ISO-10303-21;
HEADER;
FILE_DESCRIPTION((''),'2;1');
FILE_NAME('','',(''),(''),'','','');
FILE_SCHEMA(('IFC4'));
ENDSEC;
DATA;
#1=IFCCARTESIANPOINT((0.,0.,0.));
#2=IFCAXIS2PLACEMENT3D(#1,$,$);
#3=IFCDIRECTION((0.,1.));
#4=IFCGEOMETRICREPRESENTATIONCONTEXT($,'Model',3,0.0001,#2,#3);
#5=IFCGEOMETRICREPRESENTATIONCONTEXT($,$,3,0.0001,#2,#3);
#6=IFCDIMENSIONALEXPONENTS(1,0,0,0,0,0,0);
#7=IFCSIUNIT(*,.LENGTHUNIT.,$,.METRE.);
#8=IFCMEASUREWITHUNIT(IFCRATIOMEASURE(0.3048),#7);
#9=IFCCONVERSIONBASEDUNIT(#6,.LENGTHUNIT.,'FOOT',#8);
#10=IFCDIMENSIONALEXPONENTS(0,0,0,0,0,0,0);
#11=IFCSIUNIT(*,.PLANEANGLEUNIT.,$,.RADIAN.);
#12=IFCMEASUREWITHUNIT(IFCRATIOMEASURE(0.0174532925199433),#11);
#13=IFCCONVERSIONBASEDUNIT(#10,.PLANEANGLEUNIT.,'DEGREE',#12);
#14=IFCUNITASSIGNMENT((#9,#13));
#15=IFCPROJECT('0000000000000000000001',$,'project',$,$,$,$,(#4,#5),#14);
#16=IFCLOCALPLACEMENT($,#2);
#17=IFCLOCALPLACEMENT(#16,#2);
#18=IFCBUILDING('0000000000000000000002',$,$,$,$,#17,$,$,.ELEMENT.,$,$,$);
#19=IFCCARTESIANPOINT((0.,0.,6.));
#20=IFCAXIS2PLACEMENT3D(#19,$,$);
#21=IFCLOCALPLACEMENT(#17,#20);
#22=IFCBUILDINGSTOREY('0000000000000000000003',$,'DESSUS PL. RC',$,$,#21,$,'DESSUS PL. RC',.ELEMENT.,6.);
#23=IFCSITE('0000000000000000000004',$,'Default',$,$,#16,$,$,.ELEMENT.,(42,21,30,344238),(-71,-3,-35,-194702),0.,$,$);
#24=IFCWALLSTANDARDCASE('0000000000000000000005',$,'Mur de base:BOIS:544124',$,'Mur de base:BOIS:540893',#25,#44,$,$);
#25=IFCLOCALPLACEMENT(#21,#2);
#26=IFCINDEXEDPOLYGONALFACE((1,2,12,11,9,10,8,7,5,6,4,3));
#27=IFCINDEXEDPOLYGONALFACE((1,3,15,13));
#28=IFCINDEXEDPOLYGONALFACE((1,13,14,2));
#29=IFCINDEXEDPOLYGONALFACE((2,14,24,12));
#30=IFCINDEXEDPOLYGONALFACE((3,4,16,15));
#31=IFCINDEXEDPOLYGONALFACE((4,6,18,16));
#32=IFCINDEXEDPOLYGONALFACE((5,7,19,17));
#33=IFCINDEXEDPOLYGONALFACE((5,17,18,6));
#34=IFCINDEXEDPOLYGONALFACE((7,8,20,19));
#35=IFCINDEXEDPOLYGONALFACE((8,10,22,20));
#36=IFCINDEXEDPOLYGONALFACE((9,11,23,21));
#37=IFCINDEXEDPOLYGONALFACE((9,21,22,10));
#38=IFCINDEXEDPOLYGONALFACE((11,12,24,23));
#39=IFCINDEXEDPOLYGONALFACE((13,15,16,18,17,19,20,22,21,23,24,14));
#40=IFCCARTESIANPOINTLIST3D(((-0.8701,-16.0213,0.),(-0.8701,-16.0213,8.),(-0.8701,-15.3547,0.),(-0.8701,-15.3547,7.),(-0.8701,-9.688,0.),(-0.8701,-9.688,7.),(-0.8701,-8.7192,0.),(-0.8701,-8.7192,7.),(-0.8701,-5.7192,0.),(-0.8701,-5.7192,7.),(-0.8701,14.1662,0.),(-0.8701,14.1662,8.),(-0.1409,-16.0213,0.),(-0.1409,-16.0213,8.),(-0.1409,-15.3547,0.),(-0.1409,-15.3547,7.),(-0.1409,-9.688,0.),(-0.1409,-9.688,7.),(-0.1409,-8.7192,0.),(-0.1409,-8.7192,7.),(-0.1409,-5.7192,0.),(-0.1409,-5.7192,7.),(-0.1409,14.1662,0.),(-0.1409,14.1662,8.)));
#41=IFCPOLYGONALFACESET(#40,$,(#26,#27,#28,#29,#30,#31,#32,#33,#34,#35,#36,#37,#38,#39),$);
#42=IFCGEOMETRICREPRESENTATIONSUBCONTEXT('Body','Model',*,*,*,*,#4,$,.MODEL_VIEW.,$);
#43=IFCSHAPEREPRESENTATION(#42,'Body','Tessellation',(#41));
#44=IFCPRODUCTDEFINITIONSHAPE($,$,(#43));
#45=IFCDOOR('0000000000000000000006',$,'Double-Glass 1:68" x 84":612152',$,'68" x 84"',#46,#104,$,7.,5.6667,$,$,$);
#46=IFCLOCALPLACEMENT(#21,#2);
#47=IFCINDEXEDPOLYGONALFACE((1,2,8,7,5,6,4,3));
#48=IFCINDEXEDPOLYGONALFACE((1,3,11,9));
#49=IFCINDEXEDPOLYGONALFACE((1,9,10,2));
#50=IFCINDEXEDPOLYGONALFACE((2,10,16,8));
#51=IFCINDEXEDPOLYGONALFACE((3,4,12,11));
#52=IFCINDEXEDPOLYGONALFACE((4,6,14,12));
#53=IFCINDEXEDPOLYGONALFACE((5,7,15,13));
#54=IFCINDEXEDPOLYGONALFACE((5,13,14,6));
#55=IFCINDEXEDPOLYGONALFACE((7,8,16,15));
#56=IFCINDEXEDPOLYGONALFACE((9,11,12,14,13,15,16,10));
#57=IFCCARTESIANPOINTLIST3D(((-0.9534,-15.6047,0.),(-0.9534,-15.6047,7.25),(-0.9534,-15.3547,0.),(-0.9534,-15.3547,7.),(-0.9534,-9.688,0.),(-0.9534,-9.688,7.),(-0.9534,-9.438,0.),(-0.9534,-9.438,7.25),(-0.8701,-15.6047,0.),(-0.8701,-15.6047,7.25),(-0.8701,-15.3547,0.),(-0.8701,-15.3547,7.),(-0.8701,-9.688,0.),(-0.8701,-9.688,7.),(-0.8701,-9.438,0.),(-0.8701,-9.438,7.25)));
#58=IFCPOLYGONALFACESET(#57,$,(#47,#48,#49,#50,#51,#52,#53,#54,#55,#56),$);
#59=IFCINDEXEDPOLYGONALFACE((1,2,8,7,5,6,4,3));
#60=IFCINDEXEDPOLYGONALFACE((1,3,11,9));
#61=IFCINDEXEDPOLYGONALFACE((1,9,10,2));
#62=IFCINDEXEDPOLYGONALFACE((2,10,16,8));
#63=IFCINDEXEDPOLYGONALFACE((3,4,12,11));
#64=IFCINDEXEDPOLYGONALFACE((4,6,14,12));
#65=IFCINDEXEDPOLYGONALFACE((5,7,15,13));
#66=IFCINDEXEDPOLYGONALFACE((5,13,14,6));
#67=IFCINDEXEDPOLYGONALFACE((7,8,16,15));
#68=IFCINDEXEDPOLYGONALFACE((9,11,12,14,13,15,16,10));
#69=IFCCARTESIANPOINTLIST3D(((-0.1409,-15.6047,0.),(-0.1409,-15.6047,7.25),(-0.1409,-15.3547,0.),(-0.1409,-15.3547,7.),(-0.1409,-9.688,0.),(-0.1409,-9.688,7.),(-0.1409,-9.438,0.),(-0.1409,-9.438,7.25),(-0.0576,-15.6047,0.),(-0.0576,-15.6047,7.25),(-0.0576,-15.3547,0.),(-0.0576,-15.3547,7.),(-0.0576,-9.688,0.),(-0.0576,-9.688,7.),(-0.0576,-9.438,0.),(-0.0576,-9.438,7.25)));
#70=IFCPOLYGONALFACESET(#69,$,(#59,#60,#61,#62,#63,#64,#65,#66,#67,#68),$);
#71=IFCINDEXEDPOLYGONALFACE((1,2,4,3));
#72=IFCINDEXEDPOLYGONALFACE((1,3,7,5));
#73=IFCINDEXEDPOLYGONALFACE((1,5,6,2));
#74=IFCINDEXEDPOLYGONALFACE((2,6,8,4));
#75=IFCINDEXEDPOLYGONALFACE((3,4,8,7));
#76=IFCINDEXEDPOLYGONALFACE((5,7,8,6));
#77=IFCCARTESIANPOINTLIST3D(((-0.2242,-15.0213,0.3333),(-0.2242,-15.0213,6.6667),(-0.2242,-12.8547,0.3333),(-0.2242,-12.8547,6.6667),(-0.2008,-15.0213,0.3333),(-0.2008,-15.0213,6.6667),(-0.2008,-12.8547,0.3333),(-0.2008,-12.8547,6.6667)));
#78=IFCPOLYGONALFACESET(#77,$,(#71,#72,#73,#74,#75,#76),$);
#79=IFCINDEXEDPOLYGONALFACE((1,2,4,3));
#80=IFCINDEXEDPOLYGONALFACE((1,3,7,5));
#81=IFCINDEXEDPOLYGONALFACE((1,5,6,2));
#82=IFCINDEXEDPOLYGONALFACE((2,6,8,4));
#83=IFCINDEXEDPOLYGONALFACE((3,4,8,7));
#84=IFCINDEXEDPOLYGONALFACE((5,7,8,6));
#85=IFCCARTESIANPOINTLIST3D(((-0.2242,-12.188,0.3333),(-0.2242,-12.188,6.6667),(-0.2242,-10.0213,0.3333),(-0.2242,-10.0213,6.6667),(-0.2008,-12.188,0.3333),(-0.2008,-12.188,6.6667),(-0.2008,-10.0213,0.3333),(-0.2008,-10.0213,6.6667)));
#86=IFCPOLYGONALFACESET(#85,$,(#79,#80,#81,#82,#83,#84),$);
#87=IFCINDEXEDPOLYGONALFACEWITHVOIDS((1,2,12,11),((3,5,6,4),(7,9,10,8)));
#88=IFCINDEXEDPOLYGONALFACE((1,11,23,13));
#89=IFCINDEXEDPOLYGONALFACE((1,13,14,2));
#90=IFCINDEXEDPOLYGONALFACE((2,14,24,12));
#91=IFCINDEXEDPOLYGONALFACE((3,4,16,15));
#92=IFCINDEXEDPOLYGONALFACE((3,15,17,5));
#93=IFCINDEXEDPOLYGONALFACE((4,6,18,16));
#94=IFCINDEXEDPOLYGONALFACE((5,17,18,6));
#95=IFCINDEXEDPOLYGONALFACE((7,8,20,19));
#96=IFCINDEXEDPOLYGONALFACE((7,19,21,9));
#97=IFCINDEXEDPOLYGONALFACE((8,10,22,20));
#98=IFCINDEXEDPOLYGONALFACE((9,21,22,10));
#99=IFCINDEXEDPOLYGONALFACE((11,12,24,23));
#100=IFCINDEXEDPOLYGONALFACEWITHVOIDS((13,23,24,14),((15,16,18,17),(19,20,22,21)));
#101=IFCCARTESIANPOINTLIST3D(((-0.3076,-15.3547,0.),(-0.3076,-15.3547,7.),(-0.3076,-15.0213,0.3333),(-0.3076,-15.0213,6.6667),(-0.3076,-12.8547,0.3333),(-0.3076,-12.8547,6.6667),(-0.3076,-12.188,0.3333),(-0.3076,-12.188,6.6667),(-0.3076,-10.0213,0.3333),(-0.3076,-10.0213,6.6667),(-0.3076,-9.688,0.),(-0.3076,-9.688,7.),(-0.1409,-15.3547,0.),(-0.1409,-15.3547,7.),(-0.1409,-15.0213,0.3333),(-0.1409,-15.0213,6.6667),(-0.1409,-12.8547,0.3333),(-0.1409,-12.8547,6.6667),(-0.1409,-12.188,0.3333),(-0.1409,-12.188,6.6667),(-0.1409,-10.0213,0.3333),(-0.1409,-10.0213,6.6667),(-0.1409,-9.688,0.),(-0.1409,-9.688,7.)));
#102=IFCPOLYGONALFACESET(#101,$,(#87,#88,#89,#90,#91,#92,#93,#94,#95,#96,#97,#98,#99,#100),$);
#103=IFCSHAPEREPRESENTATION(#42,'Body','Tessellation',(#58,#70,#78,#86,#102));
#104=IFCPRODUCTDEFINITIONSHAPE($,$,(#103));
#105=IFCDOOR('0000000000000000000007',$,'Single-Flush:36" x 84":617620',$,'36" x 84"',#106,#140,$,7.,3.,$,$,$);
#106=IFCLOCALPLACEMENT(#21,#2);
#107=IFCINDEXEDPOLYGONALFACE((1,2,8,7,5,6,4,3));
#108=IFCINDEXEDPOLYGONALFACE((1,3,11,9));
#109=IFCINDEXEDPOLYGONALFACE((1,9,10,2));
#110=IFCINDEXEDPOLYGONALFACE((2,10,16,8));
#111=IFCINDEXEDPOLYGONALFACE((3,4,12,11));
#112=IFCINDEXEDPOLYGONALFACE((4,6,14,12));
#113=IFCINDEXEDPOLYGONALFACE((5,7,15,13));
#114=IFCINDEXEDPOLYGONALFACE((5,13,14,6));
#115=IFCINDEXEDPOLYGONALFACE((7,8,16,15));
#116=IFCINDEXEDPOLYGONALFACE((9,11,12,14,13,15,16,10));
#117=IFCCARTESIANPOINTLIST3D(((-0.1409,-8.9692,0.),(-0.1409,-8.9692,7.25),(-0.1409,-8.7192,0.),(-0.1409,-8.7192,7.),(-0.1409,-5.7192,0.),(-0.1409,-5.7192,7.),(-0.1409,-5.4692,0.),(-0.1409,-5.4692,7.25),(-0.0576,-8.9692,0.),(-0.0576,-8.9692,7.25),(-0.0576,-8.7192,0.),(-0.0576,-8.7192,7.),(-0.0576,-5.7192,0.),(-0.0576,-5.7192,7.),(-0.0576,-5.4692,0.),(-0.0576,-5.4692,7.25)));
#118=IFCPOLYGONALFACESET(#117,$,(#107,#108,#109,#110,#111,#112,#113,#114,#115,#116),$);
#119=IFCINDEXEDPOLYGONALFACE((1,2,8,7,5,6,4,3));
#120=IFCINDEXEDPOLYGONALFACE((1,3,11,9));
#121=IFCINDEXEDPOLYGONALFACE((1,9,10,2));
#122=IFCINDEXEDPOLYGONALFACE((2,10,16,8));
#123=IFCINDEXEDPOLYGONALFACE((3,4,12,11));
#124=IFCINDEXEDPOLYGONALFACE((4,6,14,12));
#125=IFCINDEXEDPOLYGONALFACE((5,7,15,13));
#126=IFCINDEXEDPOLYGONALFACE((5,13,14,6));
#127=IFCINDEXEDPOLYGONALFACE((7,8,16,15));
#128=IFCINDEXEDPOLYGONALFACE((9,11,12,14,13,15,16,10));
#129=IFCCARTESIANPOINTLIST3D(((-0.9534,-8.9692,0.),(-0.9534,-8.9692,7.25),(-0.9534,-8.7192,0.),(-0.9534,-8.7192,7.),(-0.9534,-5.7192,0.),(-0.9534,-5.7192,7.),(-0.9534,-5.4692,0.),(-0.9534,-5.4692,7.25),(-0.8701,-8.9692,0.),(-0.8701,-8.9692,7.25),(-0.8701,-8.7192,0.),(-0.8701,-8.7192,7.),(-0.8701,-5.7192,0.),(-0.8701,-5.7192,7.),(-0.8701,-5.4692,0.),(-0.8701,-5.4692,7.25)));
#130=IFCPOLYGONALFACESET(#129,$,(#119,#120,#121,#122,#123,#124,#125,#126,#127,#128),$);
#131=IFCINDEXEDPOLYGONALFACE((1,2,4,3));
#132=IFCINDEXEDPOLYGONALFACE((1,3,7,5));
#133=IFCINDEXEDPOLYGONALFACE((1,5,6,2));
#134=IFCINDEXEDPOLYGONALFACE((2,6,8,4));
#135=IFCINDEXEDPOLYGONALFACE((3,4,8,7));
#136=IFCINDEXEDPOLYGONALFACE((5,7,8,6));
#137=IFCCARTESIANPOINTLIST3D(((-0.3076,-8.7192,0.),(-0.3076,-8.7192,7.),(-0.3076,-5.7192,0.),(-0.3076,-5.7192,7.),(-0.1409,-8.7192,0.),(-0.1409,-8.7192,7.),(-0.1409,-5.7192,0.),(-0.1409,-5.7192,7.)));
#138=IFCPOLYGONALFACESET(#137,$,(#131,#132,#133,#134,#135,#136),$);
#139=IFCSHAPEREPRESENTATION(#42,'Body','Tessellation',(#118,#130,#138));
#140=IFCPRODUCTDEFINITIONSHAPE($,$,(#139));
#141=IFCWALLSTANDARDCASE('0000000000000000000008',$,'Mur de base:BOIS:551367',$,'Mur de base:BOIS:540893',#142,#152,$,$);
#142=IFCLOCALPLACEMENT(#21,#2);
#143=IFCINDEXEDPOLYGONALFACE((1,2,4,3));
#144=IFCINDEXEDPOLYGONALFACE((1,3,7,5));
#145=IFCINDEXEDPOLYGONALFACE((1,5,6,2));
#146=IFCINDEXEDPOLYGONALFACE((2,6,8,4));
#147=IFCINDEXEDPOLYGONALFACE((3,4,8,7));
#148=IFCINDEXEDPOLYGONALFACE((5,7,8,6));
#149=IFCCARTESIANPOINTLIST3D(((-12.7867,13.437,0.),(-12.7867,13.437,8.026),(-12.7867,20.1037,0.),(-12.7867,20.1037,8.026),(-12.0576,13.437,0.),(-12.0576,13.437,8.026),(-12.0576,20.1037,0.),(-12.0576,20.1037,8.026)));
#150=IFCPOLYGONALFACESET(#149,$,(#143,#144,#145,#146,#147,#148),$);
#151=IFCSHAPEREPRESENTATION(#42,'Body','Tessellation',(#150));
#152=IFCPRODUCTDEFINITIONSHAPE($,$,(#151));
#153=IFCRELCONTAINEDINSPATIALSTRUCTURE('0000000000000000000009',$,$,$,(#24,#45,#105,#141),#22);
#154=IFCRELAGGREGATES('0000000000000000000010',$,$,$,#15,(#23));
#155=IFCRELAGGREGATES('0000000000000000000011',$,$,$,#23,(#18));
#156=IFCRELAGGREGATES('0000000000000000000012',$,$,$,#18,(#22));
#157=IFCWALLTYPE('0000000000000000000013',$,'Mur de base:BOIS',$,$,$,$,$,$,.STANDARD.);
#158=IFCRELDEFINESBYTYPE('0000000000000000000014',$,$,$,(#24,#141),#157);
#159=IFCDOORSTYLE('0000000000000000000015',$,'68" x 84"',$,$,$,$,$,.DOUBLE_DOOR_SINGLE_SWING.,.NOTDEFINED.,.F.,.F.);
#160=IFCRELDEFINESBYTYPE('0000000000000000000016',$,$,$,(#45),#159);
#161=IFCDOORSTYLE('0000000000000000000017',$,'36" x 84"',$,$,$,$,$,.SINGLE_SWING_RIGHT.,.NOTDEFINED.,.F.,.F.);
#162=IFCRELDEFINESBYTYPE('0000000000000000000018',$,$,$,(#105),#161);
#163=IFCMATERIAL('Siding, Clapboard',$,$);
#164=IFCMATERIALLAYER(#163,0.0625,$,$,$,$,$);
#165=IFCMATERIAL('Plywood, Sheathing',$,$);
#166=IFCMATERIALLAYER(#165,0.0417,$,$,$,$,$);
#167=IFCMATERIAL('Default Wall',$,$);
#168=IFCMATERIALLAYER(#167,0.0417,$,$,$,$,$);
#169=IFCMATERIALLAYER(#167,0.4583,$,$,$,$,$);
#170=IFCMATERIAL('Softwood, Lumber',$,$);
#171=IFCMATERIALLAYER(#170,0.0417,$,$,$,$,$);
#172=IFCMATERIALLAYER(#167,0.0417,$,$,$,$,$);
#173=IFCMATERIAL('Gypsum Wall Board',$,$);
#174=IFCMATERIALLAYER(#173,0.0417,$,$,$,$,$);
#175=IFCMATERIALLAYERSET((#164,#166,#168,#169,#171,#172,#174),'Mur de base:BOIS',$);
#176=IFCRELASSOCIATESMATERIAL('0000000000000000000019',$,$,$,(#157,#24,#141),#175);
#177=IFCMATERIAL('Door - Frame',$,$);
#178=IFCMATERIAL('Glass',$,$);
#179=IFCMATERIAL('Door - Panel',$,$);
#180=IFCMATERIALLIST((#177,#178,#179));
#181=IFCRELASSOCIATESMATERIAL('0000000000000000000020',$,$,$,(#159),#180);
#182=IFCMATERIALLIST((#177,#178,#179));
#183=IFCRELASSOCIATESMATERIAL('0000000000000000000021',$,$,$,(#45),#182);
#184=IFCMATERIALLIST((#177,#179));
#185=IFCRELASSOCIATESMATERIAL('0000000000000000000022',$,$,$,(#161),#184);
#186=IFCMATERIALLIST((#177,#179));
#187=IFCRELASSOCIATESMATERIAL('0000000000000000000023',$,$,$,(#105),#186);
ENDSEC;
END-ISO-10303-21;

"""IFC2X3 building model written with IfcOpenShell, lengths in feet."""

from ifc_helpers import new_model, entity, si_unit, converted_unit, direction, frame, frame_2d, origin, origin_2d_with_axis, place, context, subcontext, project, spatial, polyline, rectangle, outline, extrude, source, transform, mapped, material, material_list, layer, layer_set, layer_usage, type_object, type_shapes, element, fill, save


model = new_model("IFC2X3")

# Units and contexts
model_context = context("Model", 3, precision=0.0001, world=origin(), true_north=direction((0.0, 1.0)))
context_of_model = context(None, 3, precision=0.0001, world=origin(), true_north=direction((0.0, 1.0)))
body_context = subcontext(model_context, "Body", "Model", "MODEL_VIEW")
ifc_project = project(units=[converted_unit("LENGTHUNIT", "FOOT", entity("IfcRatioMeasure", 0.3048), si_unit("LENGTHUNIT", "METRE"), dimensions=[1, 0, 0, 0, 0, 0, 0]), converted_unit("PLANEANGLEUNIT", "DEGREE", entity("IfcRatioMeasure", 0.0174532925199433), si_unit("PLANEANGLEUNIT", "RADIAN"), dimensions=[0, 0, 0, 0, 0, 0, 0])], contexts=[model_context, context_of_model])

# Site, building, storey
site_placement = place(None, origin())
site = spatial("IfcSite", under=ifc_project, at=site_placement, Name="Default", CompositionType="ELEMENT", RefLatitude=(42, 21, 30, 344238), RefLongitude=(-71, -3, -35, -194702), RefElevation=0.0)
building_placement = place(site_placement, origin())
building = spatial("IfcBuilding", under=site, at=building_placement, CompositionType="ELEMENT")
storey_placement = place(building_placement, frame((0.0, 0.0, 6.0)))
storey = spatial("IfcBuildingStorey", under=building, at=storey_placement, Name="DESSUS PL. RC", LongName="DESSUS PL. RC", CompositionType="ELEMENT", Elevation=6.0)

# Wall, openings, doors
ifc_material_1 = material(Name="Siding, Clapboard")
ifc_layer_1 = layer(ifc_material_1, 0.0625)
ifc_material_2 = material(Name="Plywood, Sheathing")
ifc_layer_2 = layer(ifc_material_2, 0.0417)
ifc_material_3 = material(Name="Default Wall")
ifc_layer_3 = layer(ifc_material_3, 0.0417)
ifc_layer_4 = layer(ifc_material_3, 0.4583)
ifc_material_4 = material(Name="Softwood, Lumber")
ifc_layer_5 = layer(ifc_material_4, 0.0417)
ifc_layer_6 = layer(ifc_material_3, 0.0417)
ifc_material_5 = material(Name="Gypsum Wall Board")
ifc_layer_7 = layer(ifc_material_5, 0.0417)
ifc_layer_set_1 = layer_set([ifc_layer_1, ifc_layer_2, ifc_layer_3, ifc_layer_4, ifc_layer_5, ifc_layer_6, ifc_layer_7], Name="Mur de base:BOIS")
ifc_layer_usage_1 = layer_usage(ifc_layer_set_1, "AXIS2", "NEGATIVE", 0.3646)
wall_type_1 = type_object("IfcWallType", Name="Mur de base:BOIS", PredefinedType="STANDARD", material=ifc_layer_set_1)
wall_1_placement = place(storey_placement, frame((-0.5055, 14.1662, 0.0), z_axis=(0.0, 0.0, 1.0), x_axis=(0.0, -1.0, 0.0)))
wall_1 = element("IfcWallStandardCase", 1, at=wall_1_placement, inside=storey, type_object=wall_type_1, material=ifc_layer_usage_1, Name="Mur de base:BOIS:544124", ObjectType="Mur de base:BOIS:540893", context=body_context, shape_type="SweptSolid", body=[
    extrude(rectangle(XDim=30.1875, YDim=0.7292, at=frame_2d((15.0938, 0.0), x_axis=(-1.0, 0.0))), origin(), (0.0, 0.0, 1.0), 8.0),
])
opening_1_placement = place(wall_1_placement, frame((23.8542, -0.3646, 0.0)))
opening_1 = element("IfcOpeningElement", 2, at=opening_1_placement, cuts=wall_1, ObjectType="Opening", context=body_context, shape_type="SweptSolid", body=[
    extrude(rectangle(XDim=5.6667, YDim=7.0, at=frame_2d((3.5, 2.8333), x_axis=(0.0, 1.0))), frame((0.0, 0.0, 0.0), z_axis=(0.0, 1.0, 0.0), x_axis=(0.0, 0.0, 1.0)), (0.0, 0.0, 1.0), 0.7292),
])
opening_2_placement = place(wall_1_placement, frame((19.8854, -0.3646, 0.0)))
opening_2 = element("IfcOpeningElement", 3, at=opening_2_placement, cuts=wall_1, ObjectType="Opening", context=body_context, shape_type="SweptSolid", body=[
    extrude(rectangle(XDim=3.0, YDim=7.0, at=frame_2d((3.5, 1.5), x_axis=(0.0, 1.0))), frame((0.0, 0.0, 0.0), z_axis=(0.0, 1.0, 0.0), x_axis=(0.0, 0.0, 1.0)), (0.0, 0.0, 1.0), 0.7292),
])
ifc_material_6 = material(Name="Door - Frame")
ifc_material_7 = material(Name="Glass")
ifc_material_8 = material(Name="Door - Panel")
ifc_material_list_1 = material_list([ifc_material_6, ifc_material_7, ifc_material_8])
ifc_material_list_2 = material_list([ifc_material_6, ifc_material_7, ifc_material_8])
door_style_1 = type_object("IfcDoorStyle", Name="68\" x 84\"", ConstructionType="NOTDEFINED", OperationType="DOUBLE_DOOR_SINGLE_SWING", ParameterTakesPrecedence=False, Sizeable=False, material=ifc_material_list_2)
shared_shape_1 = source(origin(), body_context, "Body", "SweptSolid", [
    extrude(outline(polyline([(-3.0833, -3.5625), (-2.8333, -3.5625), (-2.8333, 3.4375), (2.8333, 3.4375), (2.8333, -3.5625), (3.0833, -3.5625), (3.0833, 3.6875), (-3.0833, 3.6875), (-3.0833, -3.5625)])), frame((2.8333, -0.0833, 3.5625), z_axis=(0.0, 1.0, 0.0), x_axis=(-1.0, 0.0, 0.0)), (0.0, 0.0, 1.0), 0.0833),
    extrude(outline(polyline([(-2.8333, -3.4375), (-2.8333, 3.5625), (-3.0833, 3.5625), (-3.0833, -3.6875), (3.0833, -3.6875), (3.0833, 3.5625), (2.8333, 3.5625), (2.8333, -3.4375), (-2.8333, -3.4375)])), frame((2.8333, 0.7292, 3.5625), z_axis=(0.0, -1.0, 0.0), x_axis=(-1.0, 0.0, 0.0)), (0.0, 0.0, -1.0), 0.0833),
    extrude(rectangle(XDim=0.0234, YDim=2.1667, at=frame_2d((0.0, 0.0), x_axis=(1.0, 0.0))), frame((4.25, 0.6576, 0.3333), z_axis=(0.0, 0.0, 1.0), x_axis=(0.0, 1.0, 0.0)), (0.0, 0.0, 1.0), 6.3333),
    extrude(rectangle(XDim=0.0234, YDim=2.1667, at=origin_2d_with_axis()), frame((1.4167, 0.6576, 0.3333), z_axis=(0.0, 0.0, 1.0), x_axis=(0.0, 1.0, 0.0)), (0.0, 0.0, 1.0), 6.3333),
    extrude(outline(polyline([(-3.5, -2.8333), (3.5, -2.8333), (3.5, 2.8333), (-3.5, 2.8333), (-3.5, -2.8333)]), holes=[polyline([(-3.1667, 0.3333), (-3.1667, 2.5), (3.1667, 2.5), (3.1667, 0.3333), (-3.1667, 0.3333)]), polyline([(-3.1667, -2.5), (-3.1667, -0.3333), (3.1667, -0.3333), (3.1667, -2.5), (-3.1667, -2.5)])]), frame((2.8333, 0.5625, 3.5), z_axis=(0.0, 1.0, 0.0), x_axis=(0.0, 0.0, -1.0)), (0.0, 0.0, 1.0), 0.1667),
])
type_shapes(door_style_1, [shared_shape_1])
door_1_placement = place(opening_1_placement, origin())
door_1 = element("IfcDoor", 4, at=door_1_placement, inside=storey, type_object=door_style_1, material=ifc_material_list_1, Name="Double-Glass 1:68\" x 84\":612152", ObjectType="68\" x 84\"", OverallHeight=7.0, OverallWidth=5.6667, context=body_context, shape_type="MappedRepresentation", body=[
    mapped(shared_shape_1, transform((0.0, 0.0, 0.0), scale=1.0)),
])
fill(opening_1, door_1)
ifc_material_list_3 = material_list([ifc_material_6, ifc_material_8])
ifc_material_list_4 = material_list([ifc_material_6, ifc_material_8])
door_style_2 = type_object("IfcDoorStyle", Name="36\" x 84\"", ConstructionType="NOTDEFINED", OperationType="SINGLE_SWING_RIGHT", ParameterTakesPrecedence=False, Sizeable=False, material=ifc_material_list_4)
shared_shape_2 = source(origin(), body_context, "Body", "SweptSolid", [
    extrude(outline(polyline([(-1.75, -3.6875), (1.75, -3.6875), (1.75, 3.5625), (1.5, 3.5625), (1.5, -3.4375), (-1.5, -3.4375), (-1.5, 3.5625), (-1.75, 3.5625), (-1.75, -3.6875)])), frame((1.5, 0.7292, 3.5625), z_axis=(0.0, 1.0, 0.0), x_axis=(1.0, 0.0, 0.0)), (0.0, 0.0, 1.0), 0.0833),
    extrude(outline(polyline([(-3.6875, -1.75), (3.5625, -1.75), (3.5625, -1.5), (-3.4375, -1.5), (-3.4375, 1.5), (3.5625, 1.5), (3.5625, 1.75), (-3.6875, 1.75), (-3.6875, -1.75)])), frame((1.5, -0.0833, 3.5625), z_axis=(0.0, 1.0, 0.0), x_axis=(0.0, 0.0, -1.0)), (0.0, 0.0, 1.0), 0.0833),
    extrude(rectangle(XDim=0.1667, YDim=3.0, at=frame_2d((0.0, 0.0), x_axis=(1.0, 0.0))), frame((1.5, 0.6458, 0.0), z_axis=(0.0, 0.0, 1.0), x_axis=(0.0, 1.0, 0.0)), (0.0, 0.0, 1.0), 7.0),
])
type_shapes(door_style_2, [shared_shape_2])
door_2_placement = place(opening_2_placement, origin())
door_2 = element("IfcDoor", 5, at=door_2_placement, inside=storey, type_object=door_style_2, material=ifc_material_list_3, Name="Single-Flush:36\" x 84\":617620", ObjectType="36\" x 84\"", OverallHeight=7.0, OverallWidth=3.0, context=body_context, shape_type="MappedRepresentation", body=[
    mapped(shared_shape_2, transform((0.0, 0.0, 0.0), scale=1.0)),
])
fill(opening_2, door_2)

# Wall
ifc_layer_usage_2 = layer_usage(ifc_layer_set_1, "AXIS2", "NEGATIVE", 0.3646)
wall_2_placement = place(storey_placement, frame((-12.4221, 20.1037, 0.0), z_axis=(0.0, 0.0, 1.0), x_axis=(0.0, -1.0, 0.0)))
element("IfcWallStandardCase", 6, at=wall_2_placement, inside=storey, type_object=wall_type_1, material=ifc_layer_usage_2, Name="Mur de base:BOIS:551367", ObjectType="Mur de base:BOIS:540893", context=body_context, shape_type="SweptSolid", body=[
    extrude(rectangle(XDim=6.6667, YDim=0.7292, at=frame_2d((3.3333, 0.0), x_axis=(-1.0, 0.0))), origin(), (0.0, 0.0, 1.0), 8.026),
])

save(model, "model.ifc")
